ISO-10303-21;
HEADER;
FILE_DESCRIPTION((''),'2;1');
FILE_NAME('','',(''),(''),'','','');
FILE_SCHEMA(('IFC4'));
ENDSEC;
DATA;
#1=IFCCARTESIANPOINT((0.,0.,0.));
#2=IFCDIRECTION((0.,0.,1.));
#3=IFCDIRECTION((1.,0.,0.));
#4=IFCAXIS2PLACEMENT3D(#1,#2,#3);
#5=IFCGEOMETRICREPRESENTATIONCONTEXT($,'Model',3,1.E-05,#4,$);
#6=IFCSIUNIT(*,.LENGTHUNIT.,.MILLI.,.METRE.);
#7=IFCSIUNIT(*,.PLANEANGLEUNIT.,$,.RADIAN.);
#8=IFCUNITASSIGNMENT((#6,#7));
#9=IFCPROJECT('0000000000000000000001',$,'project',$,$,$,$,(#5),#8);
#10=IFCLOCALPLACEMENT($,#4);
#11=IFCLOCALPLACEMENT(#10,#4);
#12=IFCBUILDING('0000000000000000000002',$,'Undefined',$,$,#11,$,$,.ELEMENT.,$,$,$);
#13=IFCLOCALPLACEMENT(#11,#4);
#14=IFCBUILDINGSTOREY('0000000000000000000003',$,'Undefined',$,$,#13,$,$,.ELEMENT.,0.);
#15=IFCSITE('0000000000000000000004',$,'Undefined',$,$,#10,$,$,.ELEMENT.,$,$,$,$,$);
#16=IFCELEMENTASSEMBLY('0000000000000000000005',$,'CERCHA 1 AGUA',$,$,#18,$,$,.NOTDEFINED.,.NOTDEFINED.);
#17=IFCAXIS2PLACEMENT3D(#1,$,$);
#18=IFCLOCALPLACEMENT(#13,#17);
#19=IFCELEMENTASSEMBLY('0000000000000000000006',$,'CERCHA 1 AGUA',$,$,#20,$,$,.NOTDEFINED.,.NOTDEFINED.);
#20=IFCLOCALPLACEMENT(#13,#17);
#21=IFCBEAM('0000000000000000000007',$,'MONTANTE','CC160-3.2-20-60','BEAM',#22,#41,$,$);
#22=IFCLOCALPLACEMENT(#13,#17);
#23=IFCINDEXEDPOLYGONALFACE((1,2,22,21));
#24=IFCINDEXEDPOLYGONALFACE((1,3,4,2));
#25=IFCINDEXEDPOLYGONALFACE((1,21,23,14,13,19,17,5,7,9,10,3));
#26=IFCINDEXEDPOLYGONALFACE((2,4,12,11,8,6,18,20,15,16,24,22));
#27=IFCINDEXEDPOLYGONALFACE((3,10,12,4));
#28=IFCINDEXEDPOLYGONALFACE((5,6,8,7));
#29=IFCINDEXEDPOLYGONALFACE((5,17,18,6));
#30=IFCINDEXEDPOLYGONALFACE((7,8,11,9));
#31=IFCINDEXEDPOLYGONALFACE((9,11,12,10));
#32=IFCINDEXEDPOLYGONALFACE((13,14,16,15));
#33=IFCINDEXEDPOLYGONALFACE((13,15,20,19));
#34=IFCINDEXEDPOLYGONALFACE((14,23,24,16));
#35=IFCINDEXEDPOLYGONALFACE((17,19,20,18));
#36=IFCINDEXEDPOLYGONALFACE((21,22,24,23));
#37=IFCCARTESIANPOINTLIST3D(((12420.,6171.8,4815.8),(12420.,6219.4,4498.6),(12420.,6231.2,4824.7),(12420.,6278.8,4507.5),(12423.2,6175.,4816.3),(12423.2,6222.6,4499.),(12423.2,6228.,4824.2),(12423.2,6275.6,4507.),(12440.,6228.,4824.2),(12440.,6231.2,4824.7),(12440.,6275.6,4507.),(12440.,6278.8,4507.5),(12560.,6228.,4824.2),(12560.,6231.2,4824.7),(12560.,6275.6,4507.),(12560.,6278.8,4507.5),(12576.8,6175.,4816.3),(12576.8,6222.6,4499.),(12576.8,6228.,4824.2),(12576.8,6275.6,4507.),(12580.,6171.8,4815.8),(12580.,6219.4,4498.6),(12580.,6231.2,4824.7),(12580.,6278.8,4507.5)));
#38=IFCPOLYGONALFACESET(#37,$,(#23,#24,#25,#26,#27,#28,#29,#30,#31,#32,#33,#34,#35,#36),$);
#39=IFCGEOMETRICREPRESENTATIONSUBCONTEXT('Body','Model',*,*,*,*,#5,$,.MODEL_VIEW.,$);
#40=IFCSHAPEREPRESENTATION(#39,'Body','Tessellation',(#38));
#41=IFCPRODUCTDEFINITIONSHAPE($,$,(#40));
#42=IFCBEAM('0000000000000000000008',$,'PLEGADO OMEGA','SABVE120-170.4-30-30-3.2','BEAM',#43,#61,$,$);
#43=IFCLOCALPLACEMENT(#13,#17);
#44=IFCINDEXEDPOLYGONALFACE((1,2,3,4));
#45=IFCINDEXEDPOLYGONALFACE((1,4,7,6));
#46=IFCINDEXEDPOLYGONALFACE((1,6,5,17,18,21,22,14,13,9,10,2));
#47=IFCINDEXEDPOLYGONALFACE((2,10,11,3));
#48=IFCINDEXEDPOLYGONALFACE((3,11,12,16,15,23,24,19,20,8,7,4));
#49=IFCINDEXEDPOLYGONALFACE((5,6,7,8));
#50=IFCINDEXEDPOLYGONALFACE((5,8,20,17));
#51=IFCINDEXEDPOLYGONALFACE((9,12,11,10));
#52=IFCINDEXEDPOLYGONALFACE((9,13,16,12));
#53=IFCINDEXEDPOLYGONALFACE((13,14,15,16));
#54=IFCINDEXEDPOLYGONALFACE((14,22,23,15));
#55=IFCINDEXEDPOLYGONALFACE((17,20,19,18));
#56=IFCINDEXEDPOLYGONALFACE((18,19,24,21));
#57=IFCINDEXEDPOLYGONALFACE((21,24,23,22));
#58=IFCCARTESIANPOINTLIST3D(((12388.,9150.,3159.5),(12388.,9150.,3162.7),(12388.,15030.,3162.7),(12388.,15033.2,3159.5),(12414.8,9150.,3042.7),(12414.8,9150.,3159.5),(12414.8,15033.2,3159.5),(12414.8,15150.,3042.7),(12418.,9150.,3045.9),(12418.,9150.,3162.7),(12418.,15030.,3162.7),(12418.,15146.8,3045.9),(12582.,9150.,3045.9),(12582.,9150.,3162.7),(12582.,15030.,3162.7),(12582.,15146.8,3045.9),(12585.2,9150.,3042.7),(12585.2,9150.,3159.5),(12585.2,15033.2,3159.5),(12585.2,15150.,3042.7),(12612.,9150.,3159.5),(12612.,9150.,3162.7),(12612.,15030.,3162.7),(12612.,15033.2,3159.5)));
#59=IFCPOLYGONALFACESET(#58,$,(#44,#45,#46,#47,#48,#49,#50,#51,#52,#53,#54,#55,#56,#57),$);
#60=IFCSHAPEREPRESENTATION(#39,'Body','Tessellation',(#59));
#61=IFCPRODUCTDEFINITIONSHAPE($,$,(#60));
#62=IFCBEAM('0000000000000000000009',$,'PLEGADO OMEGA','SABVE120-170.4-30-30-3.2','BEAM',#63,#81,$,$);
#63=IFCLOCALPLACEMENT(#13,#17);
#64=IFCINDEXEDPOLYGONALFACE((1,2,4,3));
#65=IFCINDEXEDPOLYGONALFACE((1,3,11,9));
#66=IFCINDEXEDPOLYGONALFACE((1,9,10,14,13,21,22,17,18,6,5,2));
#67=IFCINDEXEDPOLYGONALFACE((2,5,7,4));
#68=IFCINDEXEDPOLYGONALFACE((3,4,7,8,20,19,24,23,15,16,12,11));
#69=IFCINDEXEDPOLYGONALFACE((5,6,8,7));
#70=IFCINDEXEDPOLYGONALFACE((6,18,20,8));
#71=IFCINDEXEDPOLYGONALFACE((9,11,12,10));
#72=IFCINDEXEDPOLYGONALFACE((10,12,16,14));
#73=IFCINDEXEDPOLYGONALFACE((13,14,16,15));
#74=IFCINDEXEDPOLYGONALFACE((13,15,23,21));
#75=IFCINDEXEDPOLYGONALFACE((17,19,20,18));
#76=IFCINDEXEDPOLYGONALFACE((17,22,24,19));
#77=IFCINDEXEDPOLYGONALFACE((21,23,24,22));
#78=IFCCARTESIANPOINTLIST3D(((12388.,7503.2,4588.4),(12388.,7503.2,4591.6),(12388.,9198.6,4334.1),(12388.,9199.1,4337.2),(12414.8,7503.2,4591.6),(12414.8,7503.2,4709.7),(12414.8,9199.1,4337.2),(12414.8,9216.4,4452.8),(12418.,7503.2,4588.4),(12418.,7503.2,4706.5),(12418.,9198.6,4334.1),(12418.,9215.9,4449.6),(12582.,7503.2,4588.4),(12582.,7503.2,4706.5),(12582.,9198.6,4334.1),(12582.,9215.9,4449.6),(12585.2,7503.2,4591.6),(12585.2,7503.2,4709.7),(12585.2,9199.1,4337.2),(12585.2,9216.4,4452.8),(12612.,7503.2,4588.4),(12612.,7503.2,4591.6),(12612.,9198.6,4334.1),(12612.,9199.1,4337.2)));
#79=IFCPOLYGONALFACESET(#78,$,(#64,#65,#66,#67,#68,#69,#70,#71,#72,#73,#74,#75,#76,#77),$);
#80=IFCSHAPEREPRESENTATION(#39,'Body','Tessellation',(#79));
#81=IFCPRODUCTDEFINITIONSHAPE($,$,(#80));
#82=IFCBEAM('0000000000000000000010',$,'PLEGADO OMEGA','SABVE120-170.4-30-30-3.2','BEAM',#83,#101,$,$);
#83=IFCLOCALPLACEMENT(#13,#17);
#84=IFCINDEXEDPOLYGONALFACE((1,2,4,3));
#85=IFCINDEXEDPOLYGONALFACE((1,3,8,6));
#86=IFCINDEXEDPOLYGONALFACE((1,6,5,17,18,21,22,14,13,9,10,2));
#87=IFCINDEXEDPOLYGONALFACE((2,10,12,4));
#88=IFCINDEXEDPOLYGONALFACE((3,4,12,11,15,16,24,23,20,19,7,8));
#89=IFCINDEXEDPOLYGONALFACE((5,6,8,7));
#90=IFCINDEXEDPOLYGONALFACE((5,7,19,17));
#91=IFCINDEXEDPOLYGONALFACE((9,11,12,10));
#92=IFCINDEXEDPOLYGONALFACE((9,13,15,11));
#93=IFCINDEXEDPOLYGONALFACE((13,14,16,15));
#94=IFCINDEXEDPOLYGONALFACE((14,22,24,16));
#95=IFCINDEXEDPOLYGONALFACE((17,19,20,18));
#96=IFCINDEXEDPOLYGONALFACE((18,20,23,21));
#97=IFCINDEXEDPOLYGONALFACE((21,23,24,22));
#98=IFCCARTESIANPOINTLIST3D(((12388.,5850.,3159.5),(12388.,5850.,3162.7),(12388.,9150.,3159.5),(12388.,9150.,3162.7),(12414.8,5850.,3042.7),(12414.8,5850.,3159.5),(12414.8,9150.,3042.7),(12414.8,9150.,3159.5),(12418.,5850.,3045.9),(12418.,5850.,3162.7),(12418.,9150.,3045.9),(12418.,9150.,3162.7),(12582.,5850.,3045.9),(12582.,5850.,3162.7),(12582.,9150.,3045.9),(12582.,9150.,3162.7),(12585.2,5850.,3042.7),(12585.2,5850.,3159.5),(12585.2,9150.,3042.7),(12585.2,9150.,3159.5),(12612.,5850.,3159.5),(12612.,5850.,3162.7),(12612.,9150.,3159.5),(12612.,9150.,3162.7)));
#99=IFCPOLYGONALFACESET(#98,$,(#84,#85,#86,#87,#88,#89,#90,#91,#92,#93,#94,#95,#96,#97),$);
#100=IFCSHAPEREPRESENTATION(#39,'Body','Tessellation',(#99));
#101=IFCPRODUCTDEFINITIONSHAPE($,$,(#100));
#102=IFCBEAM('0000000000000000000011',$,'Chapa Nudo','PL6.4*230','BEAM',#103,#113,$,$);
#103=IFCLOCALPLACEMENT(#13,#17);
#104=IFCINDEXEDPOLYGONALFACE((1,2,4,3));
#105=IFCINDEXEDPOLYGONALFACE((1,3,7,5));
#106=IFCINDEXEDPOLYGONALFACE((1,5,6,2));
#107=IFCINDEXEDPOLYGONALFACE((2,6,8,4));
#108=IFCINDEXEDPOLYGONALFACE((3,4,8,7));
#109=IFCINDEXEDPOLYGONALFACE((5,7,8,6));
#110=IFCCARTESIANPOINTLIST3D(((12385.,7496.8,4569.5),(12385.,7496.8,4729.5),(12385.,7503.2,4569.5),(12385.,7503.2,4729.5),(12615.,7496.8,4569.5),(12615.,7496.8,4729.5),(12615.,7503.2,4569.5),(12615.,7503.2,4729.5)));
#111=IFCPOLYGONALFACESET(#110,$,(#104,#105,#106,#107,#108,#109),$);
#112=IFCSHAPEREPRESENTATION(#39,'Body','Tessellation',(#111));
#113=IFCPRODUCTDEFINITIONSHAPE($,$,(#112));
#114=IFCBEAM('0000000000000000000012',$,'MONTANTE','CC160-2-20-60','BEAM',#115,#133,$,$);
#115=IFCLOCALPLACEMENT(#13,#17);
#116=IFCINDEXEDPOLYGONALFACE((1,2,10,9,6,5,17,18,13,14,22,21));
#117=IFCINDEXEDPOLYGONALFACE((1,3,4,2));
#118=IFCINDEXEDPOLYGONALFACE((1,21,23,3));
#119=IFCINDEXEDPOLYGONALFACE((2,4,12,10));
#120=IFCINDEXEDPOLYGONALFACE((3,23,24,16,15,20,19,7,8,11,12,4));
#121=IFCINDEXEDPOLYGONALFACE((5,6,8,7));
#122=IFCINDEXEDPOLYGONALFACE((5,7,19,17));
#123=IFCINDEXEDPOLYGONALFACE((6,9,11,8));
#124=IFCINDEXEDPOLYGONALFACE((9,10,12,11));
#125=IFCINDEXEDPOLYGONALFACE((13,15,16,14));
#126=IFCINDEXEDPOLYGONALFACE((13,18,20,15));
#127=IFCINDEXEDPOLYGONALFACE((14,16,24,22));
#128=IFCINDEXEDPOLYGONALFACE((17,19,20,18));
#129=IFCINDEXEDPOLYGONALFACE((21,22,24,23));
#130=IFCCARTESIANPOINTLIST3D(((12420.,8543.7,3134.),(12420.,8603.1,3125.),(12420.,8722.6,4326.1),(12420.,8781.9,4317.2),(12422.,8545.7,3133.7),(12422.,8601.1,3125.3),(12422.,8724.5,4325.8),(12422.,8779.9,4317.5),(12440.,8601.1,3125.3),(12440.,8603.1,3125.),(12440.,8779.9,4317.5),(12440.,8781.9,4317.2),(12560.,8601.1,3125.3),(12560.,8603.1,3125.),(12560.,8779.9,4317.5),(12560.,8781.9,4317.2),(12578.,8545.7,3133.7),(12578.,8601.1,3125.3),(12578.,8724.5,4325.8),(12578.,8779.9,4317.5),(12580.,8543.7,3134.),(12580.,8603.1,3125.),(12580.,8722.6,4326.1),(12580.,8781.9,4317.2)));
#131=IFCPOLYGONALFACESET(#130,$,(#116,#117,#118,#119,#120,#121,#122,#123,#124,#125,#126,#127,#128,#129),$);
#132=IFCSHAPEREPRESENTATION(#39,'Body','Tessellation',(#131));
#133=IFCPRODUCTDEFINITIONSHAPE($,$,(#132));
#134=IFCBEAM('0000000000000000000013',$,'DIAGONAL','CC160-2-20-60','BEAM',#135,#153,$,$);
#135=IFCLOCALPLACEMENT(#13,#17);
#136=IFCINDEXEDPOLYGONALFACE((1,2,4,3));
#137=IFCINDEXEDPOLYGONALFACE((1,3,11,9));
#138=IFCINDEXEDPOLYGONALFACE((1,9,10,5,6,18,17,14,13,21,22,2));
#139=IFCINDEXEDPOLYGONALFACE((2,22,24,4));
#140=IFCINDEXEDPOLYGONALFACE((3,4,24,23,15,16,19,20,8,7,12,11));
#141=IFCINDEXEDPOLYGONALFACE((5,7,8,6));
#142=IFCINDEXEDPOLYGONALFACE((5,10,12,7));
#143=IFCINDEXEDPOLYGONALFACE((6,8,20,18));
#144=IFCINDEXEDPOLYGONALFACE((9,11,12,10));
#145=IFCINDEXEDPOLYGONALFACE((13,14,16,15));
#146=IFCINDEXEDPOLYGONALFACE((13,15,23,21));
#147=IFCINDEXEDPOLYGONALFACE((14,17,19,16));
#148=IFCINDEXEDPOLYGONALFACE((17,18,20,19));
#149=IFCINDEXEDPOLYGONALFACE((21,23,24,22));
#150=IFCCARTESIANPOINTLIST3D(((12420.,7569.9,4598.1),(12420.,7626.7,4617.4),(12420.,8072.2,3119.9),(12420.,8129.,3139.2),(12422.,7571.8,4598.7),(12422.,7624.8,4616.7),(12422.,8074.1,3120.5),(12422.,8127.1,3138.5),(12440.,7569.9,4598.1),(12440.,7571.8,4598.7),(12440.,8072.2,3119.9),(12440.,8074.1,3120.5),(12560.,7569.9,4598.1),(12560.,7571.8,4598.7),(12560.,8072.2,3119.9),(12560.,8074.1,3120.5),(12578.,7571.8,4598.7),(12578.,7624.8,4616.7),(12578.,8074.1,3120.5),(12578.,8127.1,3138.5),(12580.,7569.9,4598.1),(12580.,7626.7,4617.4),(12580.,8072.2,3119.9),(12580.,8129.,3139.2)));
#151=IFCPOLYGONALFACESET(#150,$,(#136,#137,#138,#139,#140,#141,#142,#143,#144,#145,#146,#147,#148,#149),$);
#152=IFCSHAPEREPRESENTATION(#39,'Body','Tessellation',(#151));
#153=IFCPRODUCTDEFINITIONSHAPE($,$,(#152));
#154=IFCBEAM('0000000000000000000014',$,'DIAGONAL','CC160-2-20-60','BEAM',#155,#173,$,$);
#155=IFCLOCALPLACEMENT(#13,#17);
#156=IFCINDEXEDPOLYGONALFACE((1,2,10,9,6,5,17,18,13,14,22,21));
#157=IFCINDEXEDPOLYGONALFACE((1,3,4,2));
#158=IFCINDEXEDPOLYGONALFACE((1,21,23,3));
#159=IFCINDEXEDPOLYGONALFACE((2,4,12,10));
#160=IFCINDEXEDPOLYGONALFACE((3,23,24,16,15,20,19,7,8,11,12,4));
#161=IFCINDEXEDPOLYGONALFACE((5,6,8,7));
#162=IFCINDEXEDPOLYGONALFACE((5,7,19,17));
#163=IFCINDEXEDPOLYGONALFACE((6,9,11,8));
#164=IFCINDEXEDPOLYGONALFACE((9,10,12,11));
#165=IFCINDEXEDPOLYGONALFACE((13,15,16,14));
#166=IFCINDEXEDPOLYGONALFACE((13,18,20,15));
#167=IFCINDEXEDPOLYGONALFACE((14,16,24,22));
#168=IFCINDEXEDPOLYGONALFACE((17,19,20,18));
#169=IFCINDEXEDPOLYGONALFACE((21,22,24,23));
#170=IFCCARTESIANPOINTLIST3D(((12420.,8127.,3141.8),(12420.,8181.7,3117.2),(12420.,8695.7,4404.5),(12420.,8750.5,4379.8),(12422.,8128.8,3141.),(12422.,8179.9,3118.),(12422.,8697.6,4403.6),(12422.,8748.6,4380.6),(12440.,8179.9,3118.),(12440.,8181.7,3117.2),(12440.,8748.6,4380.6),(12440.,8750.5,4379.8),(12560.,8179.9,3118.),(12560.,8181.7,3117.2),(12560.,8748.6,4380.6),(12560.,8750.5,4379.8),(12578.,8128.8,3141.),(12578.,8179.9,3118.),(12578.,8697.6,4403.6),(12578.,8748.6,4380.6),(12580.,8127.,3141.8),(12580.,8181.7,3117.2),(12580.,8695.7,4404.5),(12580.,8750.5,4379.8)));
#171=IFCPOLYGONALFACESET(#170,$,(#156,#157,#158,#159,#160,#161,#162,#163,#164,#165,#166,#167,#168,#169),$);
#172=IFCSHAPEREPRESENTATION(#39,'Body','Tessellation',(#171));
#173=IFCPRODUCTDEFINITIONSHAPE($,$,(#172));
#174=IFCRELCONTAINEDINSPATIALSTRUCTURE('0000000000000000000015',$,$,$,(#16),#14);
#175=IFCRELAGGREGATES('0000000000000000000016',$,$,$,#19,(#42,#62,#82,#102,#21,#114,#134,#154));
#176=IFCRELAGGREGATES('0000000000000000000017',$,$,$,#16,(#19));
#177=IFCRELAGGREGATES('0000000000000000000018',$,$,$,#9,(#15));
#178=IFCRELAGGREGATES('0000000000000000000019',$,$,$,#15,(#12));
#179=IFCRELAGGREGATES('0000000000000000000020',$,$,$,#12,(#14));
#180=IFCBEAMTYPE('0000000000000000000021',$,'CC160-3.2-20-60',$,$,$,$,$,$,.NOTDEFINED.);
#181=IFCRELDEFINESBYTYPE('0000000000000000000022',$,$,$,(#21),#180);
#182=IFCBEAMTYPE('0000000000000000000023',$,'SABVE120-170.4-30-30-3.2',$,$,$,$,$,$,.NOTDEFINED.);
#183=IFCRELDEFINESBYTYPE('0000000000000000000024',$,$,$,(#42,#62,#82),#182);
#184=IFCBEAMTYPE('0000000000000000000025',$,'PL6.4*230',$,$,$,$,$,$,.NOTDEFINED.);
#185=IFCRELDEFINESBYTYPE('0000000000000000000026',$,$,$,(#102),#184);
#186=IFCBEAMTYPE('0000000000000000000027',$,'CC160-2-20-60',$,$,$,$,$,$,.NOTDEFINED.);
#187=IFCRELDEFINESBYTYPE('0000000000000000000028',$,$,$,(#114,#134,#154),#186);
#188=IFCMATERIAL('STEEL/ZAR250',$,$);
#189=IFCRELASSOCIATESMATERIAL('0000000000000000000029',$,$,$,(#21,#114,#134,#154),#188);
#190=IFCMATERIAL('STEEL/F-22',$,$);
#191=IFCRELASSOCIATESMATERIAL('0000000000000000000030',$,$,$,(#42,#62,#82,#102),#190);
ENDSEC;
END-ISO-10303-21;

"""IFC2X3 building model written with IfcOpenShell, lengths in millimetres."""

from ifc_helpers import new_model, si_unit, frame, origin_with_axes, origin_2d_with_axis, place, context, subcontext, project, spatial, polyline, rectangle, c_section, outline, extrude, clip, halfspace, material, type_object, element, aggregate, save


model = new_model("IFC2X3")

# Units and contexts
model_context = context("Model", 3, precision=1e-05, world=origin_with_axes())
body_context = subcontext(model_context, "Body", "Model", "MODEL_VIEW")
ifc_project = project(units=[si_unit("LENGTHUNIT", "METRE", prefix="MILLI"), si_unit("PLANEANGLEUNIT", "RADIAN")], contexts=[model_context])

# Site, building, storey
site_placement = place(None, origin_with_axes())
site = spatial("IfcSite", under=ifc_project, at=site_placement, Name="Undefined", CompositionType="ELEMENT")
building_placement = place(site_placement, origin_with_axes())
building = spatial("IfcBuilding", under=site, at=building_placement, Name="Undefined", CompositionType="ELEMENT")
storey_placement = place(building_placement, origin_with_axes())
storey = spatial("IfcBuildingStorey", under=building, at=storey_placement, Name="Undefined", CompositionType="ELEMENT", Elevation=0.0)

# Element assemblies, beams
assembly_1_placement = place(storey_placement, origin_with_axes())
assembly_1 = element("IfcElementAssembly", 1, at=assembly_1_placement, inside=storey, Name="CERCHA 1 AGUA", AssemblyPlace="NOTDEFINED", PredefinedType="NOTDEFINED")
assembly_2_placement = place(assembly_1_placement, origin_with_axes())
assembly_2 = element("IfcElementAssembly", 2, at=assembly_2_placement, Name="CERCHA 1 AGUA", AssemblyPlace="NOTDEFINED", PredefinedType="NOTDEFINED")
ifc_material_1 = material(Name="STEEL/ZAR250")
beam_type_1 = type_object("IfcBeamType", Name="CC160-3.2-20-60", PredefinedType="NOTDEFINED")
beam_1_placement = place(assembly_2_placement, frame((12500.0, 6249.1, 4503.0), z_axis=(1.0, 0.0, 0.0), x_axis=(0.0, -0.14834, 0.988936)))
beam_1 = element("IfcBeam", 3, at=beam_1_placement, type_object=beam_type_1, material=ifc_material_1, Name="MONTANTE", Description="CC160-3.2-20-60", ObjectType="BEAM", context=body_context, shape_type="SweptSolid", body=[
    extrude(c_section(Depth=160.0, Width=60.0, WallThickness=3.2, Girth=20.0, at=origin_2d_with_axis()), frame((320.8, 0.0, 0.0), z_axis=(-1.0, 0.0, 0.0), x_axis=(0.0, -1.0, 0.0)), (0.0, 0.0, 1.0), 320.8),
])
ifc_material_2 = material(Name="STEEL/F-22")
beam_type_2 = type_object("IfcBeamType", Name="SABVE120-170.4-30-30-3.2", PredefinedType="NOTDEFINED")
beam_2_placement = place(assembly_2_placement, frame((12500.0, 9150.0, 3102.7), z_axis=(0.0, 0.0, 1.0), x_axis=(0.0, 1.0, 0.0)))
beam_2 = element("IfcBeam", 4, at=beam_2_placement, type_object=beam_type_2, material=ifc_material_2, Name="PLEGADO OMEGA", Description="SABVE120-170.4-30-30-3.2", ObjectType="BEAM", context=body_context, shape_type="Clipping", body=[
    clip(extrude(outline(polyline([(82.0, 60.0), (112.0, 60.0), (112.0, 56.8), (85.2, 56.8), (85.2, -60.0), (-85.2, -60.0), (-85.2, 56.8), (-112.0, 56.8), (-112.0, 60.0), (-82.0, 60.0), (-82.0, -56.8), (82.0, -56.8), (82.0, 60.0)])), frame((6000.6, 0.0, 0.0), z_axis=(-1.0, 0.0, 0.0), x_axis=(0.0, -1.0, 0.0)), (0.0, 0.0, 1.0), 6000.6), halfspace(frame((5880.0, 0.0, 60.0), z_axis=(0.707106, 0.0, 0.707108), x_axis=(0.0, 1.0, 0.0)), False)),
])
beam_3_placement = place(assembly_2_placement, frame((12500.0, 9207.5, 4393.4), z_axis=(0.0, -0.14834, -0.988936), x_axis=(0.0, -0.988936, 0.14834)))
beam_3 = element("IfcBeam", 5, at=beam_3_placement, type_object=beam_type_2, material=ifc_material_2, Name="PLEGADO OMEGA", Description="SABVE120-170.4-30-30-3.2", ObjectType="BEAM", context=body_context, shape_type="Clipping", body=[
    clip(extrude(outline(polyline([(82.0, 60.0), (112.0, 60.0), (112.0, 56.8), (85.2, 56.8), (85.2, -60.0), (-85.2, -60.0), (-85.2, 56.8), (-112.0, 56.8), (-112.0, 60.0), (-82.0, 60.0), (-82.0, -56.8), (82.0, -56.8), (82.0, 60.0)])), frame((1750.2, 0.0, 0.0), z_axis=(-1.0, 0.0, 0.0), x_axis=(0.0, -1.0, 0.0)), (0.0, 0.0, 1.0), 1750.2), halfspace(frame((1723.3, 0.0, 0.0), z_axis=(0.988936, 0.0, 0.14834), x_axis=(0.0, -1.0, 0.0)), False)),
])
beam_4_placement = place(assembly_2_placement, frame((12500.0, 5850.0, 3102.7), z_axis=(0.0, 0.0, 1.0), x_axis=(0.0, 1.0, 0.0)))
beam_4 = element("IfcBeam", 6, at=beam_4_placement, type_object=beam_type_2, material=ifc_material_2, Name="PLEGADO OMEGA", Description="SABVE120-170.4-30-30-3.2", ObjectType="BEAM", context=body_context, shape_type="SweptSolid", body=[
    extrude(outline(polyline([(82.0, 60.0), (112.0, 60.0), (112.0, 56.8), (85.2, 56.8), (85.2, -60.0), (-85.2, -60.0), (-85.2, 56.8), (-112.0, 56.8), (-112.0, 60.0), (-82.0, 60.0), (-82.0, -56.8), (82.0, -56.8), (82.0, 60.0)])), frame((3300.0, 0.0, 0.0), z_axis=(-1.0, 0.0, 0.0), x_axis=(0.0, -1.0, 0.0)), (0.0, 0.0, 1.0), 3300.0),
])
beam_type_3 = type_object("IfcBeamType", Name="PL6.4*230", PredefinedType="NOTDEFINED")
beam_5_placement = place(assembly_2_placement, frame((12500.0, 7500.0, 4729.5), z_axis=(1.0, 0.0, 0.0), x_axis=(0.0, 0.0, -1.0)))
beam_5 = element("IfcBeam", 7, at=beam_5_placement, type_object=beam_type_3, material=ifc_material_2, Name="Chapa Nudo", Description="PL6.4*230", ObjectType="BEAM", context=body_context, shape_type="SweptSolid", body=[
    extrude(rectangle(XDim=6.4, YDim=230.0, at=origin_2d_with_axis()), frame((160.0, 0.0, 0.0), z_axis=(-1.0, 0.0, 0.0), x_axis=(0.0, -1.0, 0.0)), (0.0, 0.0, 1.0), 160.0),
])
beam_type_4 = type_object("IfcBeamType", Name="CC160-2-20-60", PredefinedType="NOTDEFINED")
beam_6_placement = place(assembly_2_placement, frame((12500.0, 8752.2, 4321.6), z_axis=(-1.0, 0.0, 0.0), x_axis=(0.0, -0.14834, -0.988936)))
beam_6 = element("IfcBeam", 8, at=beam_6_placement, type_object=beam_type_4, material=ifc_material_1, Name="MONTANTE", Description="CC160-2-20-60", ObjectType="BEAM", context=body_context, shape_type="SweptSolid", body=[
    extrude(c_section(Depth=160.0, Width=60.0, WallThickness=2.0, Girth=20.0, at=origin_2d_with_axis()), frame((1205.5, 0.0, 0.0), z_axis=(-1.0, 0.0, 0.0), x_axis=(0.0, -1.0, 0.0)), (0.0, 0.0, 1.0), 1205.5),
])
beam_7_placement = place(assembly_2_placement, frame((12500.0, 8100.6, 3129.5), z_axis=(-1.0, 0.0, 0.0), x_axis=(0.0, -0.321737, 0.946829)))
beam_7 = element("IfcBeam", 9, at=beam_7_placement, type_object=beam_type_4, material=ifc_material_1, Name="DIAGONAL", Description="CC160-2-20-60", ObjectType="BEAM", context=body_context, shape_type="SweptSolid", body=[
    extrude(c_section(Depth=160.0, Width=60.0, WallThickness=2.0, Girth=20.0, at=origin_2d_with_axis()), frame((1561.2, 0.0, 0.0), z_axis=(-1.0, 0.0, 0.0), x_axis=(0.0, -1.0, 0.0)), (0.0, 0.0, 1.0), 1561.2),
])
beam_8_placement = place(assembly_2_placement, frame((12500.0, 8723.1, 4392.1), z_axis=(-1.0, 0.0, 0.0), x_axis=(0.0, -0.410706, -0.911768)))
beam_8 = element("IfcBeam", 10, at=beam_8_placement, type_object=beam_type_4, material=ifc_material_1, Name="DIAGONAL", Description="CC160-2-20-60", ObjectType="BEAM", context=body_context, shape_type="SweptSolid", body=[
    extrude(c_section(Depth=160.0, Width=60.0, WallThickness=2.0, Girth=20.0, at=origin_2d_with_axis()), frame((1384.8, 0.0, 0.0), z_axis=(-1.0, 0.0, 0.0), x_axis=(0.0, -1.0, 0.0)), (0.0, 0.0, 1.0), 1384.8),
])

aggregate(assembly_2, [beam_2, beam_3, beam_4, beam_5, beam_1, beam_6, beam_7, beam_8])
aggregate(assembly_1, [assembly_2])

save(model, "model.ifc")
